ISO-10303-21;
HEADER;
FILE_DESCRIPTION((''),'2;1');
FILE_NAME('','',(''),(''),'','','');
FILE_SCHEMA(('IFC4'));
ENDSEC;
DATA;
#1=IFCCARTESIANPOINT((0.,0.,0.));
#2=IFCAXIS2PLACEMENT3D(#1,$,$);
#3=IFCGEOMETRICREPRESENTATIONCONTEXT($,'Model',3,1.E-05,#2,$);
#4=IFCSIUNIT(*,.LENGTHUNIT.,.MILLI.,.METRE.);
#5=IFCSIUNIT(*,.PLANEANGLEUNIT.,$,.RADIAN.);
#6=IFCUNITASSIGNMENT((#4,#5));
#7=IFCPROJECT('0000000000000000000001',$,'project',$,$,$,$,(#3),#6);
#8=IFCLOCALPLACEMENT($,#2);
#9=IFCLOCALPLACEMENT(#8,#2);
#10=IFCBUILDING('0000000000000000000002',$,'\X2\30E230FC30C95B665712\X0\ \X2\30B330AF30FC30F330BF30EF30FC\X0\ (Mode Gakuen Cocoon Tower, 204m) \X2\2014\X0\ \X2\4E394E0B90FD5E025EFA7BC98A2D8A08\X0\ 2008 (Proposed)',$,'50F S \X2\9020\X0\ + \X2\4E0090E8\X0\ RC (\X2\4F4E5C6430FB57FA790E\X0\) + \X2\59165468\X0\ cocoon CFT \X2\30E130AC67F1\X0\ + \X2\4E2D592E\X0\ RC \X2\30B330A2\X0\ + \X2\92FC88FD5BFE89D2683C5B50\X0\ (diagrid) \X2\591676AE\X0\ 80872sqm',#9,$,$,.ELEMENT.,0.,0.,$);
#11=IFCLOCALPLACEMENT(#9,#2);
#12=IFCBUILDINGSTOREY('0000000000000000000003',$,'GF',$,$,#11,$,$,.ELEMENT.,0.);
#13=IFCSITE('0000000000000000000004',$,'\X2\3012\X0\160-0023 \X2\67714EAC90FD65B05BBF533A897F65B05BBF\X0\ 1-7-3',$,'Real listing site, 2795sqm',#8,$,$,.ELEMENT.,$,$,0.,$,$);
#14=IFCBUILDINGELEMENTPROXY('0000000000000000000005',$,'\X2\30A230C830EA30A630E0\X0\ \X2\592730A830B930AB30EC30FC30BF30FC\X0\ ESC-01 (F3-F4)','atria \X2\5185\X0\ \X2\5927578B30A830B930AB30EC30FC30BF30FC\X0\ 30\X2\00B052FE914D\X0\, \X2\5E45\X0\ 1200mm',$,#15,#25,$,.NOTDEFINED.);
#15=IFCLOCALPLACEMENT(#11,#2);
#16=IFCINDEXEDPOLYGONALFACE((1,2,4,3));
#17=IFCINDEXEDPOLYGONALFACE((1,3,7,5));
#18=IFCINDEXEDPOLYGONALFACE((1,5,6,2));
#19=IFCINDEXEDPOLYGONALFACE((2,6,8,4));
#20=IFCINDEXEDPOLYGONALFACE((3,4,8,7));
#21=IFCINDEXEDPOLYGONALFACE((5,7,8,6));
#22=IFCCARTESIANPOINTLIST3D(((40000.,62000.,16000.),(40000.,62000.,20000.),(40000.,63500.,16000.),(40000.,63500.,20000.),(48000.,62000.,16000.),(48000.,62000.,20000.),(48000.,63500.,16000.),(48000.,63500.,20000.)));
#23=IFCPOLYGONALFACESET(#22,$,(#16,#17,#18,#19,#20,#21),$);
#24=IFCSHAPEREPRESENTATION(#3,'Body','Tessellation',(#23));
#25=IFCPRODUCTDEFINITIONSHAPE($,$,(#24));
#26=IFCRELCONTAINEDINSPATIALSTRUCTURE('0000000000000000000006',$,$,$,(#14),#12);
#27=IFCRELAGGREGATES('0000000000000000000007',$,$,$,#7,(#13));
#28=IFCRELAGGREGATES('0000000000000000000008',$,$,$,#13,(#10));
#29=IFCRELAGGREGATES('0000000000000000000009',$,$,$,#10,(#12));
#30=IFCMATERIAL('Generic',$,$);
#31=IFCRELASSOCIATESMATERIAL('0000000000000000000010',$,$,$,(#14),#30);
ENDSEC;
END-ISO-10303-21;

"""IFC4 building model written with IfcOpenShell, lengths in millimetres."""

from ifc_helpers import new_model, si_unit, frame, frame_2d, origin, place, context, project, spatial, rectangle, extrude, material, element, save


model = new_model("IFC4")

# Units and contexts
model_context = context("Model", 3, precision=1e-05, world=origin())
ifc_project = project(units=[si_unit("LENGTHUNIT", "METRE", prefix="MILLI"), si_unit("PLANEANGLEUNIT", "RADIAN")], contexts=[model_context])

# Site, building, storey
site_placement = place(None, origin())
site = spatial("IfcSite", under=ifc_project, at=site_placement, Name="〒160-0023 東京都新宿区西新宿 1-7-3", ObjectType="Real listing site, 2795sqm", CompositionType="ELEMENT", RefElevation=0.0)
building_placement = place(site_placement, origin())
building = spatial("IfcBuilding", under=site, at=building_placement, Name="モード学園 コクーンタワー (Mode Gakuen Cocoon Tower, 204m) — 丹下都市建築設計 2008 (Proposed)", ObjectType="50F S 造 + 一部 RC (低層・基礎) + 外周 cocoon CFT メガ柱 + 中央 RC コア + 鋼製対角格子 (diagrid) 外皮 80872sqm", CompositionType="ELEMENT", ElevationOfRefHeight=0.0, ElevationOfTerrain=0.0)
storey_placement = place(building_placement, origin())
storey = spatial("IfcBuildingStorey", under=building, at=storey_placement, Name="GF", CompositionType="ELEMENT", Elevation=0.0)

# Shared definitions
ifc_material_1 = material(Name="Generic")

# Building element proxy
proxy_1_placement = place(storey_placement, frame((20000.0, 31000.0, 8000.0)))
element("IfcBuildingElementProxy", 1, at=proxy_1_placement, inside=storey, material=ifc_material_1, Name="アトリウム 大エスカレーター ESC-01 (F3-F4)", Description="atria 内 大型エスカレーター 30°勾配, 幅 1200mm", PredefinedType="NOTDEFINED", context=model_context, shape_type="SweptSolid", body=[
    extrude(rectangle(XDim=8000.0, YDim=1500.0, at=frame_2d((4000.0, 750.0))), frame((20000.0, 31000.0, 8000.0)), (0.0, 0.0, 1.0), 4000.0),
])

save(model, "model.ifc")
